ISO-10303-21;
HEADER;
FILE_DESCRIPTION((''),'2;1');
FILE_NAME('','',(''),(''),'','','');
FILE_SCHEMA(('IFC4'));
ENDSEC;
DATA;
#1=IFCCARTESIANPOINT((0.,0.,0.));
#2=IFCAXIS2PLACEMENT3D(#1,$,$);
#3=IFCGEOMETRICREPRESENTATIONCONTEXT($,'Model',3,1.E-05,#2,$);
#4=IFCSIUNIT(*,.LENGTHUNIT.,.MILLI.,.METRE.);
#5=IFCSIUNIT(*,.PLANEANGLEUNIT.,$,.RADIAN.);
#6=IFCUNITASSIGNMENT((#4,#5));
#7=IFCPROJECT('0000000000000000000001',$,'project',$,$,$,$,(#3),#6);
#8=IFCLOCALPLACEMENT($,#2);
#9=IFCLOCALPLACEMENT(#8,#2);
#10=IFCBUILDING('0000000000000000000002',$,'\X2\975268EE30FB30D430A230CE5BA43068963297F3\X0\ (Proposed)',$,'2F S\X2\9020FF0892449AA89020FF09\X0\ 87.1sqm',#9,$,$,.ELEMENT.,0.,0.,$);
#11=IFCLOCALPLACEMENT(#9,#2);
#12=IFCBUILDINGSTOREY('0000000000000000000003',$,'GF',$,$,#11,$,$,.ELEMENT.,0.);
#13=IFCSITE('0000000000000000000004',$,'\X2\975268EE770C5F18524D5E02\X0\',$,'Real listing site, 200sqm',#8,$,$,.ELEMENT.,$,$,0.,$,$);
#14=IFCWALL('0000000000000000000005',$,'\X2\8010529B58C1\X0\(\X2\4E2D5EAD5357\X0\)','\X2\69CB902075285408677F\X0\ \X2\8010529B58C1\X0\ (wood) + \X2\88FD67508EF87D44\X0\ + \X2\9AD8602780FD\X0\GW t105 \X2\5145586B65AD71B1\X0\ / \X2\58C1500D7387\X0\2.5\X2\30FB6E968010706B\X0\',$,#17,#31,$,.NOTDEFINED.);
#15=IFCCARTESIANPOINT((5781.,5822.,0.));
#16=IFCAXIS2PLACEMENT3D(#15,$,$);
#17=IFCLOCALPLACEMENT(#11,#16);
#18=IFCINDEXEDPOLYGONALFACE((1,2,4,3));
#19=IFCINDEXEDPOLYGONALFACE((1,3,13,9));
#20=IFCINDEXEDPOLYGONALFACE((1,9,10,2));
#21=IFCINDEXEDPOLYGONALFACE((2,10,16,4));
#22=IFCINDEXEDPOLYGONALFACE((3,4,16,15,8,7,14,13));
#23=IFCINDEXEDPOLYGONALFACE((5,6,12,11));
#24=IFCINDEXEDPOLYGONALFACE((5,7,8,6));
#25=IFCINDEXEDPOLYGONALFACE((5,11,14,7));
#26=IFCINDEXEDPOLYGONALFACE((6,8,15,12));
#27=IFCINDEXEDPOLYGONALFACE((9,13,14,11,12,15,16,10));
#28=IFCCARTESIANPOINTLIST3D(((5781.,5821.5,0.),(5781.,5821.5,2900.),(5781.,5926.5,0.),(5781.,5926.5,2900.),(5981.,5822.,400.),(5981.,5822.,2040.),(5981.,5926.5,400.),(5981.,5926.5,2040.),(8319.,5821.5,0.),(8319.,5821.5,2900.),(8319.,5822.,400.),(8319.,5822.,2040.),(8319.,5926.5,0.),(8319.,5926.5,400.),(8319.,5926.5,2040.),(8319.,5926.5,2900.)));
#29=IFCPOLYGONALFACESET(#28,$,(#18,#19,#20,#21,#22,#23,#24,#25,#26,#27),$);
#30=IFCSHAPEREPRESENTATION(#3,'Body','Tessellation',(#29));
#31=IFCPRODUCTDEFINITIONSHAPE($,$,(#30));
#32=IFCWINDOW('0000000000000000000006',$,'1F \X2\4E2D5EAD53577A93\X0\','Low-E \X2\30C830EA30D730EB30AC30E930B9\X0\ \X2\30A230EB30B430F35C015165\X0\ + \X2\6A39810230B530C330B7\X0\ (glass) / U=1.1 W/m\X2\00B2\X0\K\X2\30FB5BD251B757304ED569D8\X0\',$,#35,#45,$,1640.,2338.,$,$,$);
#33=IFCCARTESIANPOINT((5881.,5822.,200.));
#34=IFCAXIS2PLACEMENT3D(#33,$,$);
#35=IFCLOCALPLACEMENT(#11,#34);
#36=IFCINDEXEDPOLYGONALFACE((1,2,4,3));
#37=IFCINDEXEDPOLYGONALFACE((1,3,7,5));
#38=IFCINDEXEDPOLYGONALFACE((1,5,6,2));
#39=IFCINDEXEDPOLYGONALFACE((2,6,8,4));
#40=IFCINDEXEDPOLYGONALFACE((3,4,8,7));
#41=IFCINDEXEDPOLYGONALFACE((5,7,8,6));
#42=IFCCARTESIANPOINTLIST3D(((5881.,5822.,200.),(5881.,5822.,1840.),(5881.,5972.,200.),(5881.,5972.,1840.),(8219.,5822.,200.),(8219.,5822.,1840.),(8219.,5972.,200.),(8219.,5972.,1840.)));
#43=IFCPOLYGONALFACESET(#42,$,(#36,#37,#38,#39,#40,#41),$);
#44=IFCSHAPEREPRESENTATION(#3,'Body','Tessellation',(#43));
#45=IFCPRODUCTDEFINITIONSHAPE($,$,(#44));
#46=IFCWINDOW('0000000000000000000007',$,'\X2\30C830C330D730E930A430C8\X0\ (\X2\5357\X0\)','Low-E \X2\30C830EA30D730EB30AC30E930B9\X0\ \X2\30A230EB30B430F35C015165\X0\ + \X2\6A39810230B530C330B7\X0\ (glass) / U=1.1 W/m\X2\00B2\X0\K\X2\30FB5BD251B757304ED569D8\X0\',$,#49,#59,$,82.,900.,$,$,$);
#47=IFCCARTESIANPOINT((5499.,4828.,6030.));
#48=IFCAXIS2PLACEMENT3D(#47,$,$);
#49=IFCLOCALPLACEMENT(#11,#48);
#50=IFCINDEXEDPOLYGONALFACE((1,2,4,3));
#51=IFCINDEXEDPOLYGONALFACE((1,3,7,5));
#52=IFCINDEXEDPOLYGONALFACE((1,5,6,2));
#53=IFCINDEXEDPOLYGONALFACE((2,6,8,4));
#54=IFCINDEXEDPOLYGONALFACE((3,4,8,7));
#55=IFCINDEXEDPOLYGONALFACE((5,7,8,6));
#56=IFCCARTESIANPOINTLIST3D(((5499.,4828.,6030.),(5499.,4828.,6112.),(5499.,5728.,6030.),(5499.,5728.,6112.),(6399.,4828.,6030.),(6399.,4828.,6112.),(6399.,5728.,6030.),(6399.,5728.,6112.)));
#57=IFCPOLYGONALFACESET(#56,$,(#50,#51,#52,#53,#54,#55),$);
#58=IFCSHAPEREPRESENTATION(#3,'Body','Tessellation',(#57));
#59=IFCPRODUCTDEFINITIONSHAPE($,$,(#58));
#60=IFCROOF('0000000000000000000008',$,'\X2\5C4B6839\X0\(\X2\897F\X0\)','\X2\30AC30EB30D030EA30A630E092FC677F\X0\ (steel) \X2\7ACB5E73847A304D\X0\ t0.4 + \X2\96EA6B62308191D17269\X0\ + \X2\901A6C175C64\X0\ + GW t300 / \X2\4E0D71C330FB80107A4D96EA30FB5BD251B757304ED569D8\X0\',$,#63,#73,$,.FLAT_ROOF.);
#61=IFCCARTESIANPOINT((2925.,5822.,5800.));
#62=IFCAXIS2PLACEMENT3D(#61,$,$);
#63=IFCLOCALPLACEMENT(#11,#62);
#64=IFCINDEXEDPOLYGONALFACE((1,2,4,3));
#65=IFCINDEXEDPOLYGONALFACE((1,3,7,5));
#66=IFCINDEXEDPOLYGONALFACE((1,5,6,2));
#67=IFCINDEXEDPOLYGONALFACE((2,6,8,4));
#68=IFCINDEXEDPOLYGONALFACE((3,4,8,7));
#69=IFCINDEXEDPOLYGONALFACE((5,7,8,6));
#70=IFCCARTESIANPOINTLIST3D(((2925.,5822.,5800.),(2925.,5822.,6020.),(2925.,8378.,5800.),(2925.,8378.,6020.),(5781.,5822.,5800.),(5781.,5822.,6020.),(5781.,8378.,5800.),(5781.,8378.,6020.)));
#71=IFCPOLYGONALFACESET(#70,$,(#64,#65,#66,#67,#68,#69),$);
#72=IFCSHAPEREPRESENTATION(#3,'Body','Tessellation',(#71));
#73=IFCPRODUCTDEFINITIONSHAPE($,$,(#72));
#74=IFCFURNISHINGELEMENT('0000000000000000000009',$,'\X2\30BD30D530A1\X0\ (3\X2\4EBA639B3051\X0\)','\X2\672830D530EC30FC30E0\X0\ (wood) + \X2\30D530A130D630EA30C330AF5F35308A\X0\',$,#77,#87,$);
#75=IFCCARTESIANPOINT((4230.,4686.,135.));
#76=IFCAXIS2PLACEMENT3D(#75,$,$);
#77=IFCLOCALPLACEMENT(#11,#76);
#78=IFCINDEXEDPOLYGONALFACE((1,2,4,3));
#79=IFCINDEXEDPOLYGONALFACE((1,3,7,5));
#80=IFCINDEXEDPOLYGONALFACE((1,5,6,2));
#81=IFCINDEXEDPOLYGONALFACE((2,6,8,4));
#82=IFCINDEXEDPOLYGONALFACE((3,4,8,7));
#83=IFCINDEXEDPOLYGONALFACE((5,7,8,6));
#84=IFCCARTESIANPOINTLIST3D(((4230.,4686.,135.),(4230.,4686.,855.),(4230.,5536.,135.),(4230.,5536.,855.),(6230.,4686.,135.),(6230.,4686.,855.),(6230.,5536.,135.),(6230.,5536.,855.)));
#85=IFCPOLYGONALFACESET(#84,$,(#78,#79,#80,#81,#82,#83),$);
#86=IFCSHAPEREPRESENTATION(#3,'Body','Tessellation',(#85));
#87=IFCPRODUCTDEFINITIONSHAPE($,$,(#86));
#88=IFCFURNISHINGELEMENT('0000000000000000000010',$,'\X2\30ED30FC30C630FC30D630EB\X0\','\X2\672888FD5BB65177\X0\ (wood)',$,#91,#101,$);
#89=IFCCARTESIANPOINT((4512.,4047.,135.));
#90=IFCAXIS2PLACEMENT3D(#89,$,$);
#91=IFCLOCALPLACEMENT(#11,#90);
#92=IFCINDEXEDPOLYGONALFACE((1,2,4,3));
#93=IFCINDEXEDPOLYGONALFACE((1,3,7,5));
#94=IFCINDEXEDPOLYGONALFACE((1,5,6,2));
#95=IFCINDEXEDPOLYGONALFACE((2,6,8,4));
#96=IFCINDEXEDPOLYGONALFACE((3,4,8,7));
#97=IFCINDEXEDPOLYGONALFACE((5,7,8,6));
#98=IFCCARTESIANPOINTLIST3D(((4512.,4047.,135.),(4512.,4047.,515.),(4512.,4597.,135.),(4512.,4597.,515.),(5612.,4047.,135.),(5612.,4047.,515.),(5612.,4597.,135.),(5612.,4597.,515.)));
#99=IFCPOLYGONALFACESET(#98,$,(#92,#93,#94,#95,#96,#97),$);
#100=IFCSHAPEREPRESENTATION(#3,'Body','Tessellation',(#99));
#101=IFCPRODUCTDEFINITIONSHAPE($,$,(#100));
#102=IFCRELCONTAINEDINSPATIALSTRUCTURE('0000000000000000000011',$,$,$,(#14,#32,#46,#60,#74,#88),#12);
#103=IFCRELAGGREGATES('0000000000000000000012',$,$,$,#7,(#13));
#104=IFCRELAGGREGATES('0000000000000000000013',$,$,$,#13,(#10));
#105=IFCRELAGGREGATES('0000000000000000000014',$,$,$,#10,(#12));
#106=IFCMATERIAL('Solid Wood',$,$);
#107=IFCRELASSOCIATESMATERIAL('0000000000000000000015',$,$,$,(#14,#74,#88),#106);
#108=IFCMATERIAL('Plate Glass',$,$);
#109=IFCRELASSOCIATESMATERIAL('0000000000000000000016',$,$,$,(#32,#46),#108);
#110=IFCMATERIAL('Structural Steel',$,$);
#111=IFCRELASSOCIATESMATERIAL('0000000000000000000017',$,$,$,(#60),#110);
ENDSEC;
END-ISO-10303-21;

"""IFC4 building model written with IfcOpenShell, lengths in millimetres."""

from ifc_helpers import new_model, si_unit, frame, frame_2d, origin, place, context, project, spatial, rectangle, extrude, material, element, fill, save


model = new_model("IFC4")

# Units and contexts
model_context = context("Model", 3, precision=1e-05, world=origin())
ifc_project = project(units=[si_unit("LENGTHUNIT", "METRE", prefix="MILLI"), si_unit("PLANEANGLEUNIT", "RADIAN")], contexts=[model_context])

# Site, building, storey
site_placement = place(None, origin())
site = spatial("IfcSite", under=ifc_project, at=site_placement, Name="青森県弘前市", ObjectType="Real listing site, 200sqm", CompositionType="ELEMENT", RefElevation=0.0)
building_placement = place(site_placement, origin())
building = spatial("IfcBuilding", under=site, at=building_placement, Name="青森・ピアノ室と防音 (Proposed)", ObjectType="2F S造（鉄骨造） 87.1sqm", CompositionType="ELEMENT", ElevationOfRefHeight=0.0, ElevationOfTerrain=0.0)
storey_placement = place(building_placement, origin())
storey = spatial("IfcBuildingStorey", under=building, at=storey_placement, Name="GF", CompositionType="ELEMENT", Elevation=0.0)

# Shared definitions
ifc_material_1 = material(Name="Solid Wood")

# Wall, opening, window
wall_placement = place(storey_placement, frame((5781.0, 5822.0, 0.0)))
wall = element("IfcWall", 1, at=wall_placement, inside=storey, material=ifc_material_1, Name="耐力壁(中庭南)", Description="構造用合板 耐力壁 (wood) + 製材軸組 + 高性能GW t105 充填断熱 / 壁倍率2.5・準耐火", PredefinedType="NOTDEFINED", context=model_context, shape_type="SweptSolid", body=[
    extrude(rectangle(XDim=2538.0, YDim=105.0, at=frame_2d((1269.0, 52.0))), frame((5781.0, 5822.0, 0.0)), (0.0, 0.0, 1.0), 2900.0),
])
opening_placement = place(storey_placement, frame((5881.0, 5822.0, 200.0)))
opening = element("IfcOpeningElement", 2, at=opening_placement, cuts=wall, PredefinedType="NOTDEFINED", context=model_context, shape_type="SweptSolid", body=[
    extrude(rectangle(XDim=2338.0, YDim=150.0, at=frame_2d((1169.0, 75.0))), frame((5881.0, 5822.0, 200.0)), (0.0, 0.0, 1.0), 1640.0),
])
ifc_material_2 = material(Name="Plate Glass")
window_1_placement = place(storey_placement, frame((5881.0, 5822.0, 200.0)))
window_1 = element("IfcWindow", 3, at=window_1_placement, inside=storey, material=ifc_material_2, Name="1F 中庭南窓", Description="Low-E トリプルガラス アルゴン封入 + 樹脂サッシ (glass) / U=1.1 W/m²K・寒冷地仕様", OverallHeight=1640.0, OverallWidth=2338.0, context=model_context, shape_type="SweptSolid", body=[
    extrude(rectangle(XDim=2338.0, YDim=150.0, at=frame_2d((1169.0, 75.0))), frame((5881.0, 5822.0, 200.0)), (0.0, 0.0, 1.0), 1640.0),
])
fill(opening, window_1)

# Window
window_2_placement = place(storey_placement, frame((5499.0, 4828.0, 6030.0)))
element("IfcWindow", 4, at=window_2_placement, inside=storey, material=ifc_material_2, Name="トップライト (南)", Description="Low-E トリプルガラス アルゴン封入 + 樹脂サッシ (glass) / U=1.1 W/m²K・寒冷地仕様", OverallHeight=82.0, OverallWidth=900.0, context=model_context, shape_type="SweptSolid", body=[
    extrude(rectangle(XDim=900.0, YDim=900.0, at=frame_2d((450.0, 450.0))), frame((5499.0, 4828.0, 6030.0)), (0.0, 0.0, 1.0), 82.0),
])

# Roof
ifc_material_3 = material(Name="Structural Steel")
for number, where, name in (
    (5, (2925.0, 5822.0, 5800.0), "屋根(西)"),
):
    element("IfcRoof", number, at=place(storey_placement, frame(where)), inside=storey, material=ifc_material_3, Name=name, Description="ガルバリウム鋼板 (steel) 立平葺き t0.4 + 雪止め金物 + 通気層 + GW t300 / 不燃・耐積雪・寒冷地仕様", PredefinedType="FLAT_ROOF", context=model_context, shape_type="SweptSolid", body=[
        extrude(rectangle(XDim=2856.0, YDim=2556.0, at=frame_2d((1428.0, 1278.0))), frame((2925.0, 5822.0, 5800.0)), (0.0, 0.0, 1.0), 220.0),
    ])

# Furnishing elements
furnishing_1_placement = place(storey_placement, frame((4230.0, 4686.0, 135.0)))
element("IfcFurnishingElement", 6, at=furnishing_1_placement, inside=storey, material=ifc_material_1, Name="ソファ (3人掛け)", Description="木フレーム (wood) + ファブリック張り", context=model_context, shape_type="SweptSolid", body=[
    extrude(rectangle(XDim=2000.0, YDim=850.0, at=frame_2d((1000.0, 425.0))), frame((4230.0, 4686.0, 135.0)), (0.0, 0.0, 1.0), 720.0),
])
furnishing_2_placement = place(storey_placement, frame((4512.0, 4047.0, 135.0)))
element("IfcFurnishingElement", 7, at=furnishing_2_placement, inside=storey, material=ifc_material_1, Name="ローテーブル", Description="木製家具 (wood)", context=model_context, shape_type="SweptSolid", body=[
    extrude(rectangle(XDim=1100.0, YDim=550.0, at=frame_2d((550.0, 275.0))), frame((4512.0, 4047.0, 135.0)), (0.0, 0.0, 1.0), 380.0),
])

save(model, "model.ifc")
